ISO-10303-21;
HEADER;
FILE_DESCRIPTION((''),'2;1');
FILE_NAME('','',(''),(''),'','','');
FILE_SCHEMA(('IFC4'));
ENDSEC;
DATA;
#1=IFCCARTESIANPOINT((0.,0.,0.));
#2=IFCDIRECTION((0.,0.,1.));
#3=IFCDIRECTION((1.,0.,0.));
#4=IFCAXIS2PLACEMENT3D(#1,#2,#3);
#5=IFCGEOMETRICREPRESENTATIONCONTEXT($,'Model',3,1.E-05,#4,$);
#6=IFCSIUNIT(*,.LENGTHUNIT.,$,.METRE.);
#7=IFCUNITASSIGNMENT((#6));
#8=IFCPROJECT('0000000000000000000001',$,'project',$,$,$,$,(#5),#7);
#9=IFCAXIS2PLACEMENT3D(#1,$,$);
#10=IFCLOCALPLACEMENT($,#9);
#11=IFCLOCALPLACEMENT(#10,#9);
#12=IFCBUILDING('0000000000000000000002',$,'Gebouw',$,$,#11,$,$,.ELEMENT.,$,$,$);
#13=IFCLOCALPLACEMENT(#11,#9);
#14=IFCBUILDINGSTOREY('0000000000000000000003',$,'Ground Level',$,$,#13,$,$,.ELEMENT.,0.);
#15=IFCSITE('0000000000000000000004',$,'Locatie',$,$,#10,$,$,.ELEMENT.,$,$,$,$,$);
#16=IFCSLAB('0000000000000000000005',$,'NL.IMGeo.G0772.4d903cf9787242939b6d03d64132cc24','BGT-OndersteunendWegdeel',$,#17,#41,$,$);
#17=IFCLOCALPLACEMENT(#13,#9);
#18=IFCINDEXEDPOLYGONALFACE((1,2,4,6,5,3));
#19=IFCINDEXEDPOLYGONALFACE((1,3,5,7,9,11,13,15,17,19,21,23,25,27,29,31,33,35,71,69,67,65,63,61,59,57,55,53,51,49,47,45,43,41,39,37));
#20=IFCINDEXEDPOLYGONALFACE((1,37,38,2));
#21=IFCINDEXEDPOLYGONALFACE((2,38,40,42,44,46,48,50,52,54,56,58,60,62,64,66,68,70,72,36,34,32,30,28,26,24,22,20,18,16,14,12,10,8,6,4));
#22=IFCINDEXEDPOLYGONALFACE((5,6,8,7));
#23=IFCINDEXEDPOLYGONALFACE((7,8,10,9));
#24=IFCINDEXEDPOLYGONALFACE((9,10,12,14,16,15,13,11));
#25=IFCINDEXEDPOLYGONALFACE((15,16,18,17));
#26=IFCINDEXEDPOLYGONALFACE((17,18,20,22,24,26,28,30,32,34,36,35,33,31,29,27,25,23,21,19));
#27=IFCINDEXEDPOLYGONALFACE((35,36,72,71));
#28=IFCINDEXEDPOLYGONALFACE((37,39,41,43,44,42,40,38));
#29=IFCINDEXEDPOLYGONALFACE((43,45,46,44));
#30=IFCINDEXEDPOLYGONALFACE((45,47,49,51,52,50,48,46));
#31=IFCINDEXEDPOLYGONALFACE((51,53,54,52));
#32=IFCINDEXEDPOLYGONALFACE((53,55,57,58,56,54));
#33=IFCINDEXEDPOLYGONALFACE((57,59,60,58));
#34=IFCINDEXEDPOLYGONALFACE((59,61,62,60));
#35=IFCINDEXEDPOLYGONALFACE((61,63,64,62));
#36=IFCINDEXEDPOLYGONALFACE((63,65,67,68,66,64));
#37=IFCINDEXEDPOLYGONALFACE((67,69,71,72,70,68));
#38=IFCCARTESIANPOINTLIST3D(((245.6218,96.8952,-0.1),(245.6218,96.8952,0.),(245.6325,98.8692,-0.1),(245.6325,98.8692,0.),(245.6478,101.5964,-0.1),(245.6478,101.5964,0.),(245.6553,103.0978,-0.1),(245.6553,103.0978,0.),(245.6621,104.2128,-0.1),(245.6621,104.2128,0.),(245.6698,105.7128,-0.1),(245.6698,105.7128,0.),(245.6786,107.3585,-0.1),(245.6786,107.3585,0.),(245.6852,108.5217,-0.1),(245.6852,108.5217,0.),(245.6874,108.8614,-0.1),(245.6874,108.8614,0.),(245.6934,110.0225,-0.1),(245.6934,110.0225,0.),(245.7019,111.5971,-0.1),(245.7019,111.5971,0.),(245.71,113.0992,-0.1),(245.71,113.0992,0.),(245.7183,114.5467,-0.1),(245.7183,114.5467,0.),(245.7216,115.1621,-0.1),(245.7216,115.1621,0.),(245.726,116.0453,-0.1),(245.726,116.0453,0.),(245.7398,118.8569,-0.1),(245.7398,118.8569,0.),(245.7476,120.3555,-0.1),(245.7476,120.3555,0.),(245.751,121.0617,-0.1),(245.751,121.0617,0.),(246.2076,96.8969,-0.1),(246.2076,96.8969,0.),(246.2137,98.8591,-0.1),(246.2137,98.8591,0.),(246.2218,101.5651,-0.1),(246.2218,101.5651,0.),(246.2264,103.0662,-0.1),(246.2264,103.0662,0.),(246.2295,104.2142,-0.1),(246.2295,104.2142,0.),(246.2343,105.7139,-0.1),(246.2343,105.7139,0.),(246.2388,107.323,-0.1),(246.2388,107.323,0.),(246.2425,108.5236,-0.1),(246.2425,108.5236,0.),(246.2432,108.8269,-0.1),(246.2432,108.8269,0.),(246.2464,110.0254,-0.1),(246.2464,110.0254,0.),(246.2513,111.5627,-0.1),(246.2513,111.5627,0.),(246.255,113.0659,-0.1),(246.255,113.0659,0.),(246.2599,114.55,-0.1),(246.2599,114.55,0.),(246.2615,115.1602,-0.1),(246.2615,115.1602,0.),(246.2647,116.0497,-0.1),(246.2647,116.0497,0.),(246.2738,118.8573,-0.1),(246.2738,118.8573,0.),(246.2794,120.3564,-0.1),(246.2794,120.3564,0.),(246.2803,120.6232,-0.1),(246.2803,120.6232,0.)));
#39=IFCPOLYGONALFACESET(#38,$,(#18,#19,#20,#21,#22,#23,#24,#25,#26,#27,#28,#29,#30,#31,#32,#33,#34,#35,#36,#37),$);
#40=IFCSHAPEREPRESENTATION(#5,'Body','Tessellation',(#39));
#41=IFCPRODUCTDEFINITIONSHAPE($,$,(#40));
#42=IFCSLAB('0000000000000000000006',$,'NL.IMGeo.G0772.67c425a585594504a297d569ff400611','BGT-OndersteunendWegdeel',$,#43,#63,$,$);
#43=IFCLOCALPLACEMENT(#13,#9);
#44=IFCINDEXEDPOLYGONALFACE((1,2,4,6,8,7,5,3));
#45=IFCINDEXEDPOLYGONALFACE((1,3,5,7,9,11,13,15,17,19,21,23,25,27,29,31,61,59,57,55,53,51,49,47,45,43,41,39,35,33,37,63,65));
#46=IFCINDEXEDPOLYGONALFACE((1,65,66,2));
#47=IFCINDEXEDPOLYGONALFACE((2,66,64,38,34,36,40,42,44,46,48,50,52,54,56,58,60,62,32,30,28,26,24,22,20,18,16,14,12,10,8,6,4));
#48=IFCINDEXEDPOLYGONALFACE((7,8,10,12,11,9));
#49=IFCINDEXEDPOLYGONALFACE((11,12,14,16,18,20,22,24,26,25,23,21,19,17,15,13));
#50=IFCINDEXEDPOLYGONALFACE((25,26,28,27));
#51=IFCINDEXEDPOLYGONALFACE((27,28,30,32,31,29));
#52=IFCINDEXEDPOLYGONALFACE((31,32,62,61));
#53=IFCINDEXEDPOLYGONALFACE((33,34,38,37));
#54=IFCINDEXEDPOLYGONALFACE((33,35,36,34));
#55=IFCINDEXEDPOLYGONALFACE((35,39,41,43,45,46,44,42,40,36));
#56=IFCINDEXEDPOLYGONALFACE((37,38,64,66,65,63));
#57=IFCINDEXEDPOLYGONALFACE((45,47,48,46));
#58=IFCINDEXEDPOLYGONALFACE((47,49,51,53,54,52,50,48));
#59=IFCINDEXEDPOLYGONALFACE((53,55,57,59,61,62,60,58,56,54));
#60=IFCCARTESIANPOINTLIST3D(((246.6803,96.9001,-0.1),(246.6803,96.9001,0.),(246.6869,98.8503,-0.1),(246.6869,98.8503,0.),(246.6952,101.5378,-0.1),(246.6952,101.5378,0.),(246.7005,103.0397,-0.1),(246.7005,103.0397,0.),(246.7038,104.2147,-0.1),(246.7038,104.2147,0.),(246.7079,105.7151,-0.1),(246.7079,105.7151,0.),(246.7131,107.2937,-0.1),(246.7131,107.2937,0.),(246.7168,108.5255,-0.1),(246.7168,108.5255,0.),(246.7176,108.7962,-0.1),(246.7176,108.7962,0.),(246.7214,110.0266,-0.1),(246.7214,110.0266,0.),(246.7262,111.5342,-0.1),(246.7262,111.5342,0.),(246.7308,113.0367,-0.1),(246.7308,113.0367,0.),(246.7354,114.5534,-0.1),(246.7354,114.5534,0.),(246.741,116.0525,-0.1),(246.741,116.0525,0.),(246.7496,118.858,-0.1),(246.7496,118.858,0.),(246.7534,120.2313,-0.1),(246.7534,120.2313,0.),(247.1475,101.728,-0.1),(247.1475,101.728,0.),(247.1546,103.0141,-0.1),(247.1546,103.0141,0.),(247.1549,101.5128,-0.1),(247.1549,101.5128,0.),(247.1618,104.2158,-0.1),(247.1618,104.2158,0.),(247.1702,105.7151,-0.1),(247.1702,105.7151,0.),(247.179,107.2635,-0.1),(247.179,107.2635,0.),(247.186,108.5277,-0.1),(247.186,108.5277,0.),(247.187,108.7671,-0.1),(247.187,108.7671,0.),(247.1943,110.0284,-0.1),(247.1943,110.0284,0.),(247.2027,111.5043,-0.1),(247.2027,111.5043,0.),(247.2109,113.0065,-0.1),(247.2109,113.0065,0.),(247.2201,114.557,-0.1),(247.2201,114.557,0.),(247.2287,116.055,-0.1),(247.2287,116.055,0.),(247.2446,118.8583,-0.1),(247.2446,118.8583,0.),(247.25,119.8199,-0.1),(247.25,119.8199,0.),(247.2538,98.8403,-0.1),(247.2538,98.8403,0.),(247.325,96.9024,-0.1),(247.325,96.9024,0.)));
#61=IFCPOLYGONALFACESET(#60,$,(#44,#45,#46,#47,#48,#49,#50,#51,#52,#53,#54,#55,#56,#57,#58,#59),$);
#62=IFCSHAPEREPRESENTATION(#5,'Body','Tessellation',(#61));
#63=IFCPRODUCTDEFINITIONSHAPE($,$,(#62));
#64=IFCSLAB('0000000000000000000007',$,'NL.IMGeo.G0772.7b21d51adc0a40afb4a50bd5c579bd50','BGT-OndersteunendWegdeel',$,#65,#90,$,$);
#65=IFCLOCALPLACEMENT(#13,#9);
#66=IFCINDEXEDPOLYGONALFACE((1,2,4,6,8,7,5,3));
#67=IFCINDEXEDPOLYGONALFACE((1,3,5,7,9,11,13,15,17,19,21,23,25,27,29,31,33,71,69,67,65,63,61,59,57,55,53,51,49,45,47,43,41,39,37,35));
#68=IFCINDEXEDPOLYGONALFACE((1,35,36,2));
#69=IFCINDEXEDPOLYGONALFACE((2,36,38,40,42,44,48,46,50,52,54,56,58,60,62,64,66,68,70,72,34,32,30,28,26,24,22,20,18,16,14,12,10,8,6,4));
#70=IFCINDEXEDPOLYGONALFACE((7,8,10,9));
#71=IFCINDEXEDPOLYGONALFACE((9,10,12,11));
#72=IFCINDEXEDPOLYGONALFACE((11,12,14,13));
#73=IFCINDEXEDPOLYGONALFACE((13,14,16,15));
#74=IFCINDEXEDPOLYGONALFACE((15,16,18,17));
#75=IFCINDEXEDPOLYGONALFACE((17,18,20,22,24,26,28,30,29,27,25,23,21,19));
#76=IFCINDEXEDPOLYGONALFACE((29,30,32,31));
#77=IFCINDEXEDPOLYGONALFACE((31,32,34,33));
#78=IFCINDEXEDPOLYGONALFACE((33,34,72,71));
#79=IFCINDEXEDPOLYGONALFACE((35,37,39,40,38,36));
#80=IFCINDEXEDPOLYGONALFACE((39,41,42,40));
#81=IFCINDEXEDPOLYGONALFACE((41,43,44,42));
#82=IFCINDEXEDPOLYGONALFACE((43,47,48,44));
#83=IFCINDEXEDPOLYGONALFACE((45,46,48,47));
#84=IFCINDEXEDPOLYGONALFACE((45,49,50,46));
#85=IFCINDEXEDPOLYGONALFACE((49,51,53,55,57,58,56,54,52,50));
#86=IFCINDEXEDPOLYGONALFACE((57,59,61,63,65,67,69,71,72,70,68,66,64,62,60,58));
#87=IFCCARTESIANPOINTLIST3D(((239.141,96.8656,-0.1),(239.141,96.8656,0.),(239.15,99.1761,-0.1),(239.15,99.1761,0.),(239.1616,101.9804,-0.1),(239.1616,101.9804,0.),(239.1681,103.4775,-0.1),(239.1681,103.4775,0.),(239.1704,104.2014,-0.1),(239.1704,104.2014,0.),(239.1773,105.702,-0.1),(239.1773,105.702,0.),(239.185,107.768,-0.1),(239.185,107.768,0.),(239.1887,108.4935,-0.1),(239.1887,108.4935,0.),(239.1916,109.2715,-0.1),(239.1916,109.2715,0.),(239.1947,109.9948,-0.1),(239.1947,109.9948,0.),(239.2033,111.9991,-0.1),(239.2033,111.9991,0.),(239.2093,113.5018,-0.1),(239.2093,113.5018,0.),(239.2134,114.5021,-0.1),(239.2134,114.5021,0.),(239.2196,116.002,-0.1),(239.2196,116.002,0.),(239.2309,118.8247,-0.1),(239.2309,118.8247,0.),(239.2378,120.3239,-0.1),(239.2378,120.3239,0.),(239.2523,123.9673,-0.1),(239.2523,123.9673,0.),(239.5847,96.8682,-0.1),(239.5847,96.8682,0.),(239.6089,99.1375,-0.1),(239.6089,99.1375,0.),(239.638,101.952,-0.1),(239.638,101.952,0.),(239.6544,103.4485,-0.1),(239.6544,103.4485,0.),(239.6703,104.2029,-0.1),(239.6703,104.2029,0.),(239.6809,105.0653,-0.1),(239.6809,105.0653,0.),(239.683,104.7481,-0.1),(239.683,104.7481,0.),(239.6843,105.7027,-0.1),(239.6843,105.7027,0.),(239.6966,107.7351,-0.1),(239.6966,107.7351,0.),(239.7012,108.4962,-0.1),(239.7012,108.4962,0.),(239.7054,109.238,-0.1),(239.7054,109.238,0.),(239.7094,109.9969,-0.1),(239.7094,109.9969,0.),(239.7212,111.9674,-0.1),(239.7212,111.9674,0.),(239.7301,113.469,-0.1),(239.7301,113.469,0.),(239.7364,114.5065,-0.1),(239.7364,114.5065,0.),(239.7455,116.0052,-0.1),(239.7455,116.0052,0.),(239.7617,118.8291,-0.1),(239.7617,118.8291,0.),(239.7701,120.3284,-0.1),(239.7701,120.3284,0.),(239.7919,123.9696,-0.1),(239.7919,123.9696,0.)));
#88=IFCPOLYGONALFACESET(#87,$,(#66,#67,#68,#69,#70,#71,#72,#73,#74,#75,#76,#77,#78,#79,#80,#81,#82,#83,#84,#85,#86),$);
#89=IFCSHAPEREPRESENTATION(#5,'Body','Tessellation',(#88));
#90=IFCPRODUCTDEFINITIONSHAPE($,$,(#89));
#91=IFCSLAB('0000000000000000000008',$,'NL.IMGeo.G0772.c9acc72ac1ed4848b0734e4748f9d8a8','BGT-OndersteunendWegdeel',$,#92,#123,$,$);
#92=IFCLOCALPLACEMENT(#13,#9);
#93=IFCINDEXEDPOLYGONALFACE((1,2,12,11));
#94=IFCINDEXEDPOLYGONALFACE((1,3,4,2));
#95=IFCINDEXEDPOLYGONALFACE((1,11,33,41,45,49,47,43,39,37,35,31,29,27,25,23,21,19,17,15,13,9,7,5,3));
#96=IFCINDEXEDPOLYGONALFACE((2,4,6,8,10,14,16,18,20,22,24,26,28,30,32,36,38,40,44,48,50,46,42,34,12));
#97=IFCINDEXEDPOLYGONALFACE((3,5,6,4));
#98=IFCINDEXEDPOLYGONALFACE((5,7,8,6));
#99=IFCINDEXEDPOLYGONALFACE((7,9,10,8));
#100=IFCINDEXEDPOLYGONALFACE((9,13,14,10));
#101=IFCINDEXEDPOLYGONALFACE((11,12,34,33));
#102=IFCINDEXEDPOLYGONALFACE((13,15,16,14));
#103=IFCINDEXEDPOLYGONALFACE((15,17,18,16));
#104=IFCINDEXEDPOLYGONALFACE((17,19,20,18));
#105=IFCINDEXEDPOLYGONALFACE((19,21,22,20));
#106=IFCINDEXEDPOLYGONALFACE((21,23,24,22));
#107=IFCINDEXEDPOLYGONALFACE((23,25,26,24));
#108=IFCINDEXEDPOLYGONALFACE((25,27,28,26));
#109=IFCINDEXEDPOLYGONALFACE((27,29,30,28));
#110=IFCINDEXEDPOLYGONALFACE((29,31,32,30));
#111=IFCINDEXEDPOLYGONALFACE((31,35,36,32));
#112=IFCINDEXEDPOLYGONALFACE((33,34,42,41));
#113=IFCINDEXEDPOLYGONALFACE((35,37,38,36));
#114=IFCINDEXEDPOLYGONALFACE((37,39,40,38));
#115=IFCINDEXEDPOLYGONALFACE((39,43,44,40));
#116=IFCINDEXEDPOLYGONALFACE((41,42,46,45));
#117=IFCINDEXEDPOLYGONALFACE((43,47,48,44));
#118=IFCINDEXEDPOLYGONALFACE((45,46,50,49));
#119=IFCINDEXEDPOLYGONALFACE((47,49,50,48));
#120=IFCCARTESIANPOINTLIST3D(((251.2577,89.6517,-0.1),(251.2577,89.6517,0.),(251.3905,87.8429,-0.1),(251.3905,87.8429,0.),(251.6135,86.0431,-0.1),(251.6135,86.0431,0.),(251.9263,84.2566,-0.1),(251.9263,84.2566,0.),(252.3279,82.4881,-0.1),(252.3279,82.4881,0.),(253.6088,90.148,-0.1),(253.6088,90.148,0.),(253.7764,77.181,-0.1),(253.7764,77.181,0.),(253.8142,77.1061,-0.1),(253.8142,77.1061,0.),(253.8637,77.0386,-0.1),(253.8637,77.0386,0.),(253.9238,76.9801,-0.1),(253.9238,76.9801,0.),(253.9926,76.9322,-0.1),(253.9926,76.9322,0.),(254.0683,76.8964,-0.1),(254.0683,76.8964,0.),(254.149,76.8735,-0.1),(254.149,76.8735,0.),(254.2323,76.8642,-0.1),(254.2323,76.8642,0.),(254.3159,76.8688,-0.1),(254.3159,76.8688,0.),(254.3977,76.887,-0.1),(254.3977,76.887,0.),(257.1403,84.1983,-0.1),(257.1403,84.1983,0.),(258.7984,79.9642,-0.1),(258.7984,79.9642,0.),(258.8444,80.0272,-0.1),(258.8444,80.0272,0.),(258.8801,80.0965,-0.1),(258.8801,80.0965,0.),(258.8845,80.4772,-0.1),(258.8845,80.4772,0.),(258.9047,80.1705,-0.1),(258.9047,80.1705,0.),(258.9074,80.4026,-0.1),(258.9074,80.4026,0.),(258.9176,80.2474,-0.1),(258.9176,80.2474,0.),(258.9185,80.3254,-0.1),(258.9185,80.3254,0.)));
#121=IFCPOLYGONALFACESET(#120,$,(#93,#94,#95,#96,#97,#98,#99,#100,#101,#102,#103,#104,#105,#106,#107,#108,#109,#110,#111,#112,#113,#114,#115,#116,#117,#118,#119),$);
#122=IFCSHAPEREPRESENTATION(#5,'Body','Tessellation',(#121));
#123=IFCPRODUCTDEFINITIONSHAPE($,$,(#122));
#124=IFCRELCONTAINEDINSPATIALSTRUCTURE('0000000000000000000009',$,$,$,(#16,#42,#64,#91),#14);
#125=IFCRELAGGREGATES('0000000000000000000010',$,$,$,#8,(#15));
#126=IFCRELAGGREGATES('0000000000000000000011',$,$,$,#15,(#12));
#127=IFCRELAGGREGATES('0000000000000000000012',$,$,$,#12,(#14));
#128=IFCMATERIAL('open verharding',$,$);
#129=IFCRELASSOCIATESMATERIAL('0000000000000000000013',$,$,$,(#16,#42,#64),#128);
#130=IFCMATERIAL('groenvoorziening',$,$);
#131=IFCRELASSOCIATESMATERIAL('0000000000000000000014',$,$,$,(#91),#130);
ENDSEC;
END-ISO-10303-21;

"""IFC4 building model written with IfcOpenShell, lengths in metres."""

from ifc_helpers import new_model, si_unit, frame, origin, origin_with_axes, place, context, project, spatial, polyline, outline, extrude, material, element, save


model = new_model("IFC4")

# Units and contexts
model_context = context("Model", 3, precision=1e-05, world=origin_with_axes())
ifc_project = project(units=[si_unit("LENGTHUNIT", "METRE")], contexts=[model_context])

# Site, building, storey
site_placement = place(None, origin())
site = spatial("IfcSite", under=ifc_project, at=site_placement, Name="Locatie", CompositionType="ELEMENT")
building_placement = place(site_placement, origin())
building = spatial("IfcBuilding", under=site, at=building_placement, Name="Gebouw", CompositionType="ELEMENT")
storey_placement = place(building_placement, origin())
storey = spatial("IfcBuildingStorey", under=building, at=storey_placement, Name="Ground Level", CompositionType="ELEMENT", Elevation=0.0)

# Slabs
ifc_material_1 = material(Name="open verharding")
slab_1_placement = place(storey_placement, origin())
element("IfcSlab", 1, at=slab_1_placement, inside=storey, material=ifc_material_1, Name="NL.IMGeo.G0772.4d903cf9787242939b6d03d64132cc24", Description="BGT-OndersteunendWegdeel", context=model_context, shape_type="SweptSolid", body=[
    extrude(outline(polyline([(246.2794, 120.3564), (246.2738, 118.8573), (246.2647, 116.0497), (246.2615, 115.1602), (246.2599, 114.55), (246.255, 113.0659), (246.2513, 111.5627), (246.2464, 110.0254), (246.2432, 108.8269), (246.2425, 108.5236), (246.2388, 107.323), (246.2343, 105.7139), (246.2295, 104.2142), (246.2264, 103.0662), (246.2218, 101.5651), (246.2137, 98.8591), (246.2076, 96.8969), (245.6218, 96.8952), (245.6325, 98.8692), (245.6478, 101.5964), (245.6553, 103.0978), (245.6621, 104.2128), (245.6698, 105.7128), (245.6786, 107.3585), (245.6852, 108.5217), (245.6874, 108.8614), (245.6934, 110.0225), (245.7019, 111.5971), (245.71, 113.0992), (245.7183, 114.5467), (245.7216, 115.1621), (245.726, 116.0453), (245.7398, 118.8569), (245.7476, 120.3555), (245.751, 121.0617), (246.2803, 120.6232), (246.2794, 120.3564)])), frame((0.0, 0.0, -0.1), z_axis=(0.0, 0.0, 1.0), x_axis=(1.0, 0.0, 0.0)), (0.0, 0.0, 1.0), 0.1),
])
slab_2_placement = place(storey_placement, origin())
element("IfcSlab", 2, at=slab_2_placement, inside=storey, material=ifc_material_1, Name="NL.IMGeo.G0772.67c425a585594504a297d569ff400611", Description="BGT-OndersteunendWegdeel", context=model_context, shape_type="SweptSolid", body=[
    extrude(outline(polyline([(247.2446, 118.8583), (247.2287, 116.055), (247.2201, 114.557), (247.2109, 113.0065), (247.2027, 111.5043), (247.1943, 110.0284), (247.187, 108.7671), (247.186, 108.5277), (247.179, 107.2635), (247.1702, 105.7151), (247.1618, 104.2158), (247.1546, 103.0141), (247.1475, 101.728), (247.1549, 101.5128), (247.2538, 98.8403), (247.325, 96.9024), (246.6803, 96.9001), (246.6869, 98.8503), (246.6952, 101.5378), (246.7005, 103.0397), (246.7038, 104.2147), (246.7079, 105.7151), (246.7131, 107.2937), (246.7168, 108.5255), (246.7176, 108.7962), (246.7214, 110.0266), (246.7262, 111.5342), (246.7308, 113.0367), (246.7354, 114.5534), (246.741, 116.0525), (246.7496, 118.858), (246.7534, 120.2313), (247.25, 119.8199), (247.2446, 118.8583)])), frame((0.0, 0.0, -0.1), z_axis=(0.0, 0.0, 1.0), x_axis=(1.0, 0.0, 0.0)), (0.0, 0.0, 1.0), 0.1),
])
slab_3_placement = place(storey_placement, origin())
element("IfcSlab", 3, at=slab_3_placement, inside=storey, material=ifc_material_1, Name="NL.IMGeo.G0772.7b21d51adc0a40afb4a50bd5c579bd50", Description="BGT-OndersteunendWegdeel", context=model_context, shape_type="SweptSolid", body=[
    extrude(outline(polyline([(239.7094, 109.9969), (239.7054, 109.238), (239.7012, 108.4962), (239.6966, 107.7351), (239.6843, 105.7027), (239.6809, 105.0653), (239.683, 104.7481), (239.6703, 104.2029), (239.6544, 103.4485), (239.638, 101.952), (239.6089, 99.1375), (239.5847, 96.8682), (239.141, 96.8656), (239.15, 99.1761), (239.1616, 101.9804), (239.1681, 103.4775), (239.1704, 104.2014), (239.1773, 105.702), (239.185, 107.768), (239.1887, 108.4935), (239.1916, 109.2715), (239.1947, 109.9948), (239.2033, 111.9991), (239.2093, 113.5018), (239.2134, 114.5021), (239.2196, 116.002), (239.2309, 118.8247), (239.2378, 120.3239), (239.2523, 123.9673), (239.7919, 123.9696), (239.7701, 120.3284), (239.7617, 118.8291), (239.7455, 116.0052), (239.7364, 114.5065), (239.7301, 113.469), (239.7212, 111.9674), (239.7094, 109.9969)])), frame((0.0, 0.0, -0.1), z_axis=(0.0, 0.0, 1.0), x_axis=(1.0, 0.0, 0.0)), (0.0, 0.0, 1.0), 0.1),
])
ifc_material_2 = material(Name="groenvoorziening")
slab_4_placement = place(storey_placement, origin())
element("IfcSlab", 4, at=slab_4_placement, inside=storey, material=ifc_material_2, Name="NL.IMGeo.G0772.c9acc72ac1ed4848b0734e4748f9d8a8", Description="BGT-OndersteunendWegdeel", context=model_context, shape_type="SweptSolid", body=[
    extrude(outline(polyline([(258.8845, 80.4772), (258.9074, 80.4026), (258.9185, 80.3254), (258.9176, 80.2474), (258.9047, 80.1705), (258.8801, 80.0965), (258.8444, 80.0272), (258.7984, 79.9642), (254.3977, 76.887), (254.3159, 76.8688), (254.2323, 76.8642), (254.149, 76.8735), (254.0683, 76.8964), (253.9926, 76.9322), (253.9238, 76.9801), (253.8637, 77.0386), (253.8142, 77.1061), (253.7764, 77.181), (252.3279, 82.4881), (251.9263, 84.2566), (251.6135, 86.0431), (251.3905, 87.8429), (251.2577, 89.6517), (253.6088, 90.148), (257.1403, 84.1983), (258.8845, 80.4772)])), frame((0.0, 0.0, -0.1), z_axis=(0.0, 0.0, 1.0), x_axis=(1.0, 0.0, 0.0)), (0.0, 0.0, 1.0), 0.1),
])

save(model, "model.ifc")
